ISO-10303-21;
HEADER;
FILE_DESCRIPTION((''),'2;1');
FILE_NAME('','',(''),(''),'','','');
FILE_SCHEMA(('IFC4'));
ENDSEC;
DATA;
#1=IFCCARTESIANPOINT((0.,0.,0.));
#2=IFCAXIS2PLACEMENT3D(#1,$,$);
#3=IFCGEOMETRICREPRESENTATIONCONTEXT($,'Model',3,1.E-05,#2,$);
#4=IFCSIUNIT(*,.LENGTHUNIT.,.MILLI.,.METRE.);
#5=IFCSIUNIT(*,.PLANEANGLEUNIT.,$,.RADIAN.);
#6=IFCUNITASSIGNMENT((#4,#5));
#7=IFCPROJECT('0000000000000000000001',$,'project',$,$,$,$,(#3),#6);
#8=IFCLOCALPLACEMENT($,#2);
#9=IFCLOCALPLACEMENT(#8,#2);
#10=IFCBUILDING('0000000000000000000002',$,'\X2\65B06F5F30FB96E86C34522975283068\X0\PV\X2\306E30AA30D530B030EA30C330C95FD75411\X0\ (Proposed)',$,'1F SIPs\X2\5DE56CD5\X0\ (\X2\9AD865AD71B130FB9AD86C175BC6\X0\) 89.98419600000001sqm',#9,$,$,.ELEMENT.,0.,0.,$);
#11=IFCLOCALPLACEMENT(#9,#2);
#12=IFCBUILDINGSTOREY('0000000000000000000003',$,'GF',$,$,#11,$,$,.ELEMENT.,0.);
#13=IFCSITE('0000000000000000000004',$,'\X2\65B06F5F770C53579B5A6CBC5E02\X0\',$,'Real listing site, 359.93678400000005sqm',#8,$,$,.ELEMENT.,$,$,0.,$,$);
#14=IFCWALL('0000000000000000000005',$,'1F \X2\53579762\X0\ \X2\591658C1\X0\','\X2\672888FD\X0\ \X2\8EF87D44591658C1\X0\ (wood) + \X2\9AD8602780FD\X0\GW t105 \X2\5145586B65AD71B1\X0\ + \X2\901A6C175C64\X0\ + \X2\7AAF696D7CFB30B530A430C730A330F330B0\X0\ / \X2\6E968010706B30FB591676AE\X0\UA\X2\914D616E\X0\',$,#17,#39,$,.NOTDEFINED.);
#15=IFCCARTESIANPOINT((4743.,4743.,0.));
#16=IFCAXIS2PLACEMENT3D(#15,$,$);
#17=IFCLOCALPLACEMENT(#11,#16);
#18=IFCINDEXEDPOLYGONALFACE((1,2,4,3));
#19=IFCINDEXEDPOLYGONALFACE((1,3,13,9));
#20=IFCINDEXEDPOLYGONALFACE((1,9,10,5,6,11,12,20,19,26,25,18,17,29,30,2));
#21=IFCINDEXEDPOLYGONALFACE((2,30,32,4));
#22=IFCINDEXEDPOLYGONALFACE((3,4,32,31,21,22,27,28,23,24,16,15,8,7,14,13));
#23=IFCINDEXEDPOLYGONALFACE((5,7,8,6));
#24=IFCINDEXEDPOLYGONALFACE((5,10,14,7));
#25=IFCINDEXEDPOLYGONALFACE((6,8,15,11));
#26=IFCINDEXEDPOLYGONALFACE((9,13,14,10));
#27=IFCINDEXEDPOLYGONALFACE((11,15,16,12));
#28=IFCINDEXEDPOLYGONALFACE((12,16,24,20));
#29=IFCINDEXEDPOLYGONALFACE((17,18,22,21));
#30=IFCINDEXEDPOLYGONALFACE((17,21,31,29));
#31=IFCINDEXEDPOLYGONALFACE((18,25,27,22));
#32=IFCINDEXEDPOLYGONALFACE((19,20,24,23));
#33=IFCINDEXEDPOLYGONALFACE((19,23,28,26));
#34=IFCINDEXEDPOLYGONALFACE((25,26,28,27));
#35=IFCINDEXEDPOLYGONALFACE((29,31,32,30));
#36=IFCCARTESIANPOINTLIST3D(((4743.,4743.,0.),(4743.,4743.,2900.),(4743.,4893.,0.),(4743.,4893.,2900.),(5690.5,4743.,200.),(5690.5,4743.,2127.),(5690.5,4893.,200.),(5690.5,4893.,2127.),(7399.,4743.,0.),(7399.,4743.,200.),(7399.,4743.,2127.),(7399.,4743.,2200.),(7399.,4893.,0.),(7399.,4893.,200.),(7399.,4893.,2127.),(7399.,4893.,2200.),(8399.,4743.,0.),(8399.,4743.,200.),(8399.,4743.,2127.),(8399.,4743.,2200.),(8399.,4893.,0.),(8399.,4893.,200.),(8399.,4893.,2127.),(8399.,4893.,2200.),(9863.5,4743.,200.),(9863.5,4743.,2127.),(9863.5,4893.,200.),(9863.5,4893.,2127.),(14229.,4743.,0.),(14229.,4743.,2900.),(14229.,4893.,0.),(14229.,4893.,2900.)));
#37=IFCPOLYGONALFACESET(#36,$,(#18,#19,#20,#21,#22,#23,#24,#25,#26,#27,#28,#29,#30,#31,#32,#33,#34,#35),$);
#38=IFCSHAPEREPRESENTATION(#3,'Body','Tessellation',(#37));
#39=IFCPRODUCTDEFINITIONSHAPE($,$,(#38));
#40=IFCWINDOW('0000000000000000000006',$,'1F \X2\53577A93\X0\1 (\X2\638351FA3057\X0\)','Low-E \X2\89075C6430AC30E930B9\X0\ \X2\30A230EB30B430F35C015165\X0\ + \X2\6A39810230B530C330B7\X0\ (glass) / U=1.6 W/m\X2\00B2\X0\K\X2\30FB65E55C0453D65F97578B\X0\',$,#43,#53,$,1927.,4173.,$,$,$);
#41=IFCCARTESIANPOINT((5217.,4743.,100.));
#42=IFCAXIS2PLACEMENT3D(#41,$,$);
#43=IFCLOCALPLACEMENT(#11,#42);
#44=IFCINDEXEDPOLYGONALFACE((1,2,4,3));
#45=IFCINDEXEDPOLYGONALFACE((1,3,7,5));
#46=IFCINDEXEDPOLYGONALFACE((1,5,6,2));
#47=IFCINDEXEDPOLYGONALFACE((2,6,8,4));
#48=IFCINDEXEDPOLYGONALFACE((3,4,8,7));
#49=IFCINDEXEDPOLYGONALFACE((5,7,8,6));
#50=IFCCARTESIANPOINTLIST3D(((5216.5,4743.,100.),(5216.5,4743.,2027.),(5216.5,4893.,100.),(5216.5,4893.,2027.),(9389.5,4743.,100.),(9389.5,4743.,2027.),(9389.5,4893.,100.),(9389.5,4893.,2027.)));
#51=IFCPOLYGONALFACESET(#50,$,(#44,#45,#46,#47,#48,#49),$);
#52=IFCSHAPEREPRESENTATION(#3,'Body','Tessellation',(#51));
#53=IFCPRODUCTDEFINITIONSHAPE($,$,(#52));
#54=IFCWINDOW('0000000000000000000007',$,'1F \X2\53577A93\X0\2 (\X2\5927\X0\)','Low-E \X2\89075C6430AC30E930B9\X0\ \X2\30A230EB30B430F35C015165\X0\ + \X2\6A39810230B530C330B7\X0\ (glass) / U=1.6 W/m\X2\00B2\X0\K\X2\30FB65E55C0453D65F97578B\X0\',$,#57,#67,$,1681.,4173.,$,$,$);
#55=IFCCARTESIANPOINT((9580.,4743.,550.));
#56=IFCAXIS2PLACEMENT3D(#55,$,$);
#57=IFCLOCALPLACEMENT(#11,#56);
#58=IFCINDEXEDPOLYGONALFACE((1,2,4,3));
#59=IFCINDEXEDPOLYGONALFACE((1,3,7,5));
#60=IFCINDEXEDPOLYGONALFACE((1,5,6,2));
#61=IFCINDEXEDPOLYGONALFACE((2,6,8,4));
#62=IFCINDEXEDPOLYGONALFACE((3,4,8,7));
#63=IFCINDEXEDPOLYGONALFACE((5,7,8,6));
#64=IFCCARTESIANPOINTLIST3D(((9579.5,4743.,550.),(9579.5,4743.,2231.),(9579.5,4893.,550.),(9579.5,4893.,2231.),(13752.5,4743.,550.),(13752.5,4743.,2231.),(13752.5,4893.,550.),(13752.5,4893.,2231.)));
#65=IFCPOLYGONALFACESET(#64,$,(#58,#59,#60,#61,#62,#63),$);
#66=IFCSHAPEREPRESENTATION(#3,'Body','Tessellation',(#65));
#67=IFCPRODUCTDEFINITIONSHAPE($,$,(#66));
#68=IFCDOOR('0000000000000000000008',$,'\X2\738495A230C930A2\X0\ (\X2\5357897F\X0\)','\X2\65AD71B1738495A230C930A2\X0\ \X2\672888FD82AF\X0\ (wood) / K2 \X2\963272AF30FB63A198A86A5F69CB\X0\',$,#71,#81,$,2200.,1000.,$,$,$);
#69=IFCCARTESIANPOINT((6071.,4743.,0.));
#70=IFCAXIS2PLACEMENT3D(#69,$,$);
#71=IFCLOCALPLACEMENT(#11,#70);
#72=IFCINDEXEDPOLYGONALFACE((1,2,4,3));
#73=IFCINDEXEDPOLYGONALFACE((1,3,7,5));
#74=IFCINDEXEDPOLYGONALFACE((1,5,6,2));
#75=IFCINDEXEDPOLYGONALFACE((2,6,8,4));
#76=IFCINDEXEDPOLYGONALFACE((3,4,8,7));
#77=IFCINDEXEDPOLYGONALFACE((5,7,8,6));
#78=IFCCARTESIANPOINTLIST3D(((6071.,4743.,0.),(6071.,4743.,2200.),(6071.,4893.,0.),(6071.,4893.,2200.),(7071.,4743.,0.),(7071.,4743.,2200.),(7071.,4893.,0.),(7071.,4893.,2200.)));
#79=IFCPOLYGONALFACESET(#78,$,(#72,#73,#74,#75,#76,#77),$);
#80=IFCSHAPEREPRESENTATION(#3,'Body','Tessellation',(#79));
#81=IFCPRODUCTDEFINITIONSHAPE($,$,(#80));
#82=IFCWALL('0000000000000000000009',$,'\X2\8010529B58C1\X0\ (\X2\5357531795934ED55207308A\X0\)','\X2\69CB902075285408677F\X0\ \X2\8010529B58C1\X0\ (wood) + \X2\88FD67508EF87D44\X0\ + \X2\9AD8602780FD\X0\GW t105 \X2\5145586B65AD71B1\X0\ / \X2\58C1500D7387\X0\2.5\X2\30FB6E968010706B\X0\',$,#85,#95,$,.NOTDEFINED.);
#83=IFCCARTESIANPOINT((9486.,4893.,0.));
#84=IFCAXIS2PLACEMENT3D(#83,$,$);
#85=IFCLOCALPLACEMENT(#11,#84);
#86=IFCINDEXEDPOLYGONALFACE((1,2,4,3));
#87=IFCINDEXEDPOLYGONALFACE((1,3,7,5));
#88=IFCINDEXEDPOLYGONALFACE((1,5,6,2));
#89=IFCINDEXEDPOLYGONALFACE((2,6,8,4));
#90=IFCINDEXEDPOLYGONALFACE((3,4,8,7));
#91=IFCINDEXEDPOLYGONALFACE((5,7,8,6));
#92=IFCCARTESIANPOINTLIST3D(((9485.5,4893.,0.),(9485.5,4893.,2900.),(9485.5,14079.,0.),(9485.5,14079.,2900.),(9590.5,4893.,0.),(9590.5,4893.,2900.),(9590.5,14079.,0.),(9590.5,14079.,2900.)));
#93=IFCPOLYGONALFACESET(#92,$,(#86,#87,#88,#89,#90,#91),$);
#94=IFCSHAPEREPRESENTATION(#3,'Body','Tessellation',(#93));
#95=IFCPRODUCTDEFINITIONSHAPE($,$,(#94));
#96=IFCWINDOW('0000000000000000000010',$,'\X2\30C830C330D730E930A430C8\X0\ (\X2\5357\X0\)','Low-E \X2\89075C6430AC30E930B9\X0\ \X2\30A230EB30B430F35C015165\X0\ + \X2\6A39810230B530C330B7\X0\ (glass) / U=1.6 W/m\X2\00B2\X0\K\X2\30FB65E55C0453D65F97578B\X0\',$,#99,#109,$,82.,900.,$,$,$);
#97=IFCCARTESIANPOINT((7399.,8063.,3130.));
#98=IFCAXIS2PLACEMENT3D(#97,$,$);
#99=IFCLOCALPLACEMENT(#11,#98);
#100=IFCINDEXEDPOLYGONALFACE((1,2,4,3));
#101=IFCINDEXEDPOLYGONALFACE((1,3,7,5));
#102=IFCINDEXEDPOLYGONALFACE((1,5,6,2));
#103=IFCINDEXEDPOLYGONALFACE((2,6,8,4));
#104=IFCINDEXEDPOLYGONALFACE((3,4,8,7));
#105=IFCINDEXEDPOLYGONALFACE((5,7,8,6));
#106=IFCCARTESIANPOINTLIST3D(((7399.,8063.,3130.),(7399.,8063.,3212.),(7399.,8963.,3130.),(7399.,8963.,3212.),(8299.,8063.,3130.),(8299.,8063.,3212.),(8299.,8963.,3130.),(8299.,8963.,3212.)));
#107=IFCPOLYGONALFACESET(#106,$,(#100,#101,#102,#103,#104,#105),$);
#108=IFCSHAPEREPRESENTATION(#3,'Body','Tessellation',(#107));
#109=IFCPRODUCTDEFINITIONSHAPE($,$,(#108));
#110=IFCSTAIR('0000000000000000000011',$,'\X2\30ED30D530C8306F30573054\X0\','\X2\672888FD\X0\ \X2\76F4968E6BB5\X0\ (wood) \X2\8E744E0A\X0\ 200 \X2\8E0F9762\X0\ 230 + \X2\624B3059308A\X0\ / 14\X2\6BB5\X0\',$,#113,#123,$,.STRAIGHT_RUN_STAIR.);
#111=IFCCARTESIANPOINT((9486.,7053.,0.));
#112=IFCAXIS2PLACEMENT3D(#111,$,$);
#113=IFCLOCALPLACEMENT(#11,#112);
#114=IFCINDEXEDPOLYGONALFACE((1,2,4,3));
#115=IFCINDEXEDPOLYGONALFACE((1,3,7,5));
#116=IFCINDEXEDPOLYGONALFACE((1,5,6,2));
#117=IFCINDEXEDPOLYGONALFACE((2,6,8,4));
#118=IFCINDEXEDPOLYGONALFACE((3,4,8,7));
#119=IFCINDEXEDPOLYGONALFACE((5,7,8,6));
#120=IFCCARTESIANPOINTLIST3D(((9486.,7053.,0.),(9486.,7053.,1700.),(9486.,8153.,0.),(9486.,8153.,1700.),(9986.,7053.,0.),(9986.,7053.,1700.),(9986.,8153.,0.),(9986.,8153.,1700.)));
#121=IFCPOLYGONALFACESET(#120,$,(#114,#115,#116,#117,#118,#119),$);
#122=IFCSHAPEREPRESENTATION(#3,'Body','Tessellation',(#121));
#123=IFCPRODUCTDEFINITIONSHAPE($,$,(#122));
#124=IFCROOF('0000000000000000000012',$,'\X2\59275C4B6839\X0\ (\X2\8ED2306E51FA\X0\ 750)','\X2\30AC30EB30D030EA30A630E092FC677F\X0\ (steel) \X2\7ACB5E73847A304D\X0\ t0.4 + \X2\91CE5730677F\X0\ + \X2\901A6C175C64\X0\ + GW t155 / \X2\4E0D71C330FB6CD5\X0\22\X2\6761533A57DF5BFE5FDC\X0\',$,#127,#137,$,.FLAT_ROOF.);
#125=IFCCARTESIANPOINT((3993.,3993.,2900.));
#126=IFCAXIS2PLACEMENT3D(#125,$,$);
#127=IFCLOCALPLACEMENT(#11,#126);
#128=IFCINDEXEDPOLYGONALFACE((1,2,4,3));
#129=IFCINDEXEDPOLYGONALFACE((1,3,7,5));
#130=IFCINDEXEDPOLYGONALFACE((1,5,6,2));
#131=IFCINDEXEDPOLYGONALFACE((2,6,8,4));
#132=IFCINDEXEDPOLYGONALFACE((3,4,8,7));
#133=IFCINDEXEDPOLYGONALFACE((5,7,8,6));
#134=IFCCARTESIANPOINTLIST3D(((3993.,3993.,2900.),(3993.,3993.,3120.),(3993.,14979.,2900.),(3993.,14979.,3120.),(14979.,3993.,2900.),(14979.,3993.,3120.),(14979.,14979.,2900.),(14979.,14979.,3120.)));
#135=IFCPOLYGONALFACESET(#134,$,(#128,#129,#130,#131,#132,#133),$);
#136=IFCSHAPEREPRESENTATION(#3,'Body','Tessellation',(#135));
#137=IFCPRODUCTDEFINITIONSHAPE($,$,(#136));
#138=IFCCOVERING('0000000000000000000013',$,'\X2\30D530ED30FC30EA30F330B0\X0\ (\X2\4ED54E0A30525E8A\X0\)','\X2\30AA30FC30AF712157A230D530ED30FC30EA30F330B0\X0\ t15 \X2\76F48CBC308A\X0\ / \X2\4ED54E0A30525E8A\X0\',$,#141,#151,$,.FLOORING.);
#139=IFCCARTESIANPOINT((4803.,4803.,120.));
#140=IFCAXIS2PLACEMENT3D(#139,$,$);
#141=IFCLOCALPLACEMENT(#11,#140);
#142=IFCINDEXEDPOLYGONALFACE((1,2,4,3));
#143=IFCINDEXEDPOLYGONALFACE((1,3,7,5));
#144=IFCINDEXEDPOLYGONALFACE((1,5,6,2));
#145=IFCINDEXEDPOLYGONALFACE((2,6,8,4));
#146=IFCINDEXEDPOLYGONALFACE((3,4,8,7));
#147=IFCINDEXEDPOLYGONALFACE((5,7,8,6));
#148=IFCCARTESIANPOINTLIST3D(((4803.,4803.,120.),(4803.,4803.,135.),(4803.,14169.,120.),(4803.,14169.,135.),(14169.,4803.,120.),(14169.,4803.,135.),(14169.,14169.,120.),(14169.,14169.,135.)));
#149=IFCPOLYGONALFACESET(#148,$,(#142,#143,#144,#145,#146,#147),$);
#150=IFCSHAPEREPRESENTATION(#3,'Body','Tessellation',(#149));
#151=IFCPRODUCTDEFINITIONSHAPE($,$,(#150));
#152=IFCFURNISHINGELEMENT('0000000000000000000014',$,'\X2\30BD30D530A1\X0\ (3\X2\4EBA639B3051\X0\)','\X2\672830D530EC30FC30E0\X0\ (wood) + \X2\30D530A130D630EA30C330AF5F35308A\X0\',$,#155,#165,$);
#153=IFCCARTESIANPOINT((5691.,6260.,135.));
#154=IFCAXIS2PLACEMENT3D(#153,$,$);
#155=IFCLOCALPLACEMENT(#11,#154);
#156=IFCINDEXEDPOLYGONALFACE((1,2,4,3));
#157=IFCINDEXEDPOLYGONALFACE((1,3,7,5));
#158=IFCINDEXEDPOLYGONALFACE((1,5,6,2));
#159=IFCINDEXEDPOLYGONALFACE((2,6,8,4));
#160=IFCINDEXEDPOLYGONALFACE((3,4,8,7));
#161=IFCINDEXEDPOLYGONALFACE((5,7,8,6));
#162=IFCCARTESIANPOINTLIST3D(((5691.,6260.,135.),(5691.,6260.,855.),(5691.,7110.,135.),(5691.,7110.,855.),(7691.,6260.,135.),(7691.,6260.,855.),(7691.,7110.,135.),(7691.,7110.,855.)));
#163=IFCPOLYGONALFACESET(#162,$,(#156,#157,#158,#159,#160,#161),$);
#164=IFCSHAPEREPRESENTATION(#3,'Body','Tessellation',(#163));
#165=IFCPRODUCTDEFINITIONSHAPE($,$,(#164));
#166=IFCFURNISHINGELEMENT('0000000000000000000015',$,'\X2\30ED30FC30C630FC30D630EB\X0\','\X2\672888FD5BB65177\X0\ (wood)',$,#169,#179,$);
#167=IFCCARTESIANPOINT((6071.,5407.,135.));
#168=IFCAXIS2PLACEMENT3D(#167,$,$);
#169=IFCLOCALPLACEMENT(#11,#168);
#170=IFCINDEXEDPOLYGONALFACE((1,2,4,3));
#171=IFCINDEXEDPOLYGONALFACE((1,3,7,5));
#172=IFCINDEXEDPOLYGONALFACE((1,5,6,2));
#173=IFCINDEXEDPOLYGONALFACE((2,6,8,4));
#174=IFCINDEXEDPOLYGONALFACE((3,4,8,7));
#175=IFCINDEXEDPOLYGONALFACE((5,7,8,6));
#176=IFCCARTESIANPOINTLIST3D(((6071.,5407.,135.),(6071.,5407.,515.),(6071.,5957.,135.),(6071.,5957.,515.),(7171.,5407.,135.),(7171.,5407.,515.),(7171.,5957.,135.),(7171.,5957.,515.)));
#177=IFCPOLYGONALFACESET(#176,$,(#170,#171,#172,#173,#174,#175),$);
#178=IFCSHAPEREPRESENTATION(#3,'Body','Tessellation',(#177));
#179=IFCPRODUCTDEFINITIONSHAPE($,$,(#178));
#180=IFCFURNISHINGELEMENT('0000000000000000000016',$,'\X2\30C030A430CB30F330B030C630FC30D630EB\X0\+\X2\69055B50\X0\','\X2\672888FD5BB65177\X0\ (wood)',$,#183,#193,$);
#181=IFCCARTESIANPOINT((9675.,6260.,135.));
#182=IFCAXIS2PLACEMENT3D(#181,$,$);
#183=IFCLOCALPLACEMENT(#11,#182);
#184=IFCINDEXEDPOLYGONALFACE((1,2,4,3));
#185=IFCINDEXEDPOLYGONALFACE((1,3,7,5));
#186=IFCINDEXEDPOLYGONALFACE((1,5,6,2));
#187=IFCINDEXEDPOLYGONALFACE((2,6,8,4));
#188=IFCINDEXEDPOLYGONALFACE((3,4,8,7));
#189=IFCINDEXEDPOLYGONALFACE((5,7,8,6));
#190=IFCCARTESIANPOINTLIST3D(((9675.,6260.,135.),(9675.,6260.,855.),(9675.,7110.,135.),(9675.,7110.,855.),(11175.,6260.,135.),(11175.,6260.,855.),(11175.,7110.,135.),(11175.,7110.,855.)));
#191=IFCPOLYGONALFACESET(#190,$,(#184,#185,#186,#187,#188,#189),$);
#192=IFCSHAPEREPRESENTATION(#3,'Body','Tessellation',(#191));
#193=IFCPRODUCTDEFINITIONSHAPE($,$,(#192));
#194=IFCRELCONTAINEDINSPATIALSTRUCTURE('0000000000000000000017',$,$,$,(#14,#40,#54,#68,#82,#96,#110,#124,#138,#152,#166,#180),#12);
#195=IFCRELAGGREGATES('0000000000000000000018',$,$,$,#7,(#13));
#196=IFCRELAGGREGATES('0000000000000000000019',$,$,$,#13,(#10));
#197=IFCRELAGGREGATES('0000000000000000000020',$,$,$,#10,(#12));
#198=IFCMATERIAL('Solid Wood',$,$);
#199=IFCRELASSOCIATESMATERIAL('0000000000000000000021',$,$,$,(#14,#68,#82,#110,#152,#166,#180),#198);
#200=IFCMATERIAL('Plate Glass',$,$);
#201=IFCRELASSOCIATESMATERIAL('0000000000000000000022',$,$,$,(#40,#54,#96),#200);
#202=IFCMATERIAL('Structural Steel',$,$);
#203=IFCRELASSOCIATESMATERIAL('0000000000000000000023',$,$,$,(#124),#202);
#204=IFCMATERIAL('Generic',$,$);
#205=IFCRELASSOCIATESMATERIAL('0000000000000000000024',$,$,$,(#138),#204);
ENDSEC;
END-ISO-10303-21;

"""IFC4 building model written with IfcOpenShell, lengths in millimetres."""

from ifc_helpers import new_model, si_unit, frame, frame_2d, origin, place, context, project, spatial, rectangle, extrude, material, element, fill, save


model = new_model("IFC4")

# Units and contexts
model_context = context("Model", 3, precision=1e-05, world=origin())
ifc_project = project(units=[si_unit("LENGTHUNIT", "METRE", prefix="MILLI"), si_unit("PLANEANGLEUNIT", "RADIAN")], contexts=[model_context])

# Site, building, storey
site_placement = place(None, origin())
site = spatial("IfcSite", under=ifc_project, at=site_placement, Name="新潟県南魚沼市", ObjectType="Real listing site, 359.93678400000005sqm", CompositionType="ELEMENT", RefElevation=0.0)
building_placement = place(site_placement, origin())
building = spatial("IfcBuilding", under=site, at=building_placement, Name="新潟・雨水利用とPVのオフグリッド志向 (Proposed)", ObjectType="1F SIPs工法 (高断熱・高気密) 89.98419600000001sqm", CompositionType="ELEMENT", ElevationOfRefHeight=0.0, ElevationOfTerrain=0.0)
storey_placement = place(building_placement, origin())
storey = spatial("IfcBuildingStorey", under=building, at=storey_placement, Name="GF", CompositionType="ELEMENT", Elevation=0.0)

# Shared definitions
ifc_material_1 = material(Name="Solid Wood")

# Wall, openings, windows, door
wall_1_placement = place(storey_placement, frame((4743.0, 4743.0, 0.0)))
wall_1 = element("IfcWall", 1, at=wall_1_placement, inside=storey, material=ifc_material_1, Name="1F 南面 外壁", Description="木製 軸組外壁 (wood) + 高性能GW t105 充填断熱 + 通気層 + 窯業系サイディング / 準耐火・外皮UA配慮", PredefinedType="NOTDEFINED", context=model_context, shape_type="SweptSolid", body=[
    extrude(rectangle(XDim=9486.0, YDim=150.0, at=frame_2d((4743.0, 75.0))), frame((4743.0, 4743.0, 0.0)), (0.0, 0.0, 1.0), 2900.0),
])
opening_1_placement = place(storey_placement, frame((5217.0, 4743.0, 100.0)))
opening_1 = element("IfcOpeningElement", 2, at=opening_1_placement, cuts=wall_1, PredefinedType="NOTDEFINED", context=model_context, shape_type="SweptSolid", body=[
    extrude(rectangle(XDim=4173.0, YDim=150.0, at=frame_2d((2086.0, 75.0))), frame((5217.0, 4743.0, 100.0)), (0.0, 0.0, 1.0), 1927.0),
])
opening_2_placement = place(storey_placement, frame((9580.0, 4743.0, 550.0)))
opening_2 = element("IfcOpeningElement", 3, at=opening_2_placement, cuts=wall_1, PredefinedType="NOTDEFINED", context=model_context, shape_type="SweptSolid", body=[
    extrude(rectangle(XDim=4173.0, YDim=150.0, at=frame_2d((2086.0, 75.0))), frame((9580.0, 4743.0, 550.0)), (0.0, 0.0, 1.0), 1681.0),
])
opening_3_placement = place(storey_placement, frame((6071.0, 4743.0, 0.0)))
opening_3 = element("IfcOpeningElement", 4, at=opening_3_placement, cuts=wall_1, PredefinedType="NOTDEFINED", context=model_context, shape_type="SweptSolid", body=[
    extrude(rectangle(XDim=1000.0, YDim=150.0, at=frame_2d((500.0, 75.0))), frame((6071.0, 4743.0, 0.0)), (0.0, 0.0, 1.0), 2200.0),
])
ifc_material_2 = material(Name="Plate Glass")
window_1_placement = place(storey_placement, frame((5217.0, 4743.0, 100.0)))
window_1 = element("IfcWindow", 5, at=window_1_placement, inside=storey, material=ifc_material_2, Name="1F 南窓1 (掃出し)", Description="Low-E 複層ガラス アルゴン封入 + 樹脂サッシ (glass) / U=1.6 W/m²K・日射取得型", OverallHeight=1927.0, OverallWidth=4173.0, context=model_context, shape_type="SweptSolid", body=[
    extrude(rectangle(XDim=4173.0, YDim=150.0, at=frame_2d((2086.0, 75.0))), frame((5217.0, 4743.0, 100.0)), (0.0, 0.0, 1.0), 1927.0),
])
fill(opening_1, window_1)
window_2_placement = place(storey_placement, frame((9580.0, 4743.0, 550.0)))
window_2 = element("IfcWindow", 6, at=window_2_placement, inside=storey, material=ifc_material_2, Name="1F 南窓2 (大)", Description="Low-E 複層ガラス アルゴン封入 + 樹脂サッシ (glass) / U=1.6 W/m²K・日射取得型", OverallHeight=1681.0, OverallWidth=4173.0, context=model_context, shape_type="SweptSolid", body=[
    extrude(rectangle(XDim=4173.0, YDim=150.0, at=frame_2d((2086.0, 75.0))), frame((9580.0, 4743.0, 550.0)), (0.0, 0.0, 1.0), 1681.0),
])
fill(opening_2, window_2)
door_placement = place(storey_placement, frame((6071.0, 4743.0, 0.0)))
door = element("IfcDoor", 7, at=door_placement, inside=storey, material=ifc_material_1, Name="玄関ドア (南西)", Description="断熱玄関ドア 木製芯 (wood) / K2 防犯・採風機構", OverallHeight=2200.0, OverallWidth=1000.0, context=model_context, shape_type="SweptSolid", body=[
    extrude(rectangle(XDim=1000.0, YDim=150.0, at=frame_2d((500.0, 75.0))), frame((6071.0, 4743.0, 0.0)), (0.0, 0.0, 1.0), 2200.0),
])
fill(opening_3, door)

# Wall
wall_2_placement = place(storey_placement, frame((9486.0, 4893.0, 0.0)))
element("IfcWall", 8, at=wall_2_placement, inside=storey, material=ifc_material_1, Name="耐力壁 (南北間仕切り)", Description="構造用合板 耐力壁 (wood) + 製材軸組 + 高性能GW t105 充填断熱 / 壁倍率2.5・準耐火", PredefinedType="NOTDEFINED", context=model_context, shape_type="SweptSolid", body=[
    extrude(rectangle(XDim=105.0, YDim=9186.0, at=frame_2d((52.0, 4593.0))), frame((9486.0, 4893.0, 0.0)), (0.0, 0.0, 1.0), 2900.0),
])

# Window
window_3_placement = place(storey_placement, frame((7399.0, 8063.0, 3130.0)))
element("IfcWindow", 9, at=window_3_placement, inside=storey, material=ifc_material_2, Name="トップライト (南)", Description="Low-E 複層ガラス アルゴン封入 + 樹脂サッシ (glass) / U=1.6 W/m²K・日射取得型", OverallHeight=82.0, OverallWidth=900.0, context=model_context, shape_type="SweptSolid", body=[
    extrude(rectangle(XDim=900.0, YDim=900.0, at=frame_2d((450.0, 450.0))), frame((7399.0, 8063.0, 3130.0)), (0.0, 0.0, 1.0), 82.0),
])

# Stair
stair_placement = place(storey_placement, frame((9486.0, 7053.0, 0.0)))
element("IfcStair", 10, at=stair_placement, inside=storey, material=ifc_material_1, Name="ロフトはしご", Description="木製 直階段 (wood) 蹴上 200 踏面 230 + 手すり / 14段", PredefinedType="STRAIGHT_RUN_STAIR", context=model_context, shape_type="SweptSolid", body=[
    extrude(rectangle(XDim=500.0, YDim=1100.0, at=frame_2d((250.0, 550.0))), frame((9486.0, 7053.0, 0.0)), (0.0, 0.0, 1.0), 1700.0),
])

# Roof
ifc_material_3 = material(Name="Structural Steel")
roof_placement = place(storey_placement, frame((3993.0, 3993.0, 2900.0)))
element("IfcRoof", 11, at=roof_placement, inside=storey, material=ifc_material_3, Name="大屋根 (軒の出 750)", Description="ガルバリウム鋼板 (steel) 立平葺き t0.4 + 野地板 + 通気層 + GW t155 / 不燃・法22条区域対応", PredefinedType="FLAT_ROOF", context=model_context, shape_type="SweptSolid", body=[
    extrude(rectangle(XDim=10986.0, YDim=10986.0, at=frame_2d((5493.0, 5493.0))), frame((3993.0, 3993.0, 2900.0)), (0.0, 0.0, 1.0), 220.0),
])

# Covering
ifc_material_4 = material(Name="Generic")
covering_placement = place(storey_placement, frame((4803.0, 4803.0, 120.0)))
element("IfcCovering", 12, at=covering_placement, inside=storey, material=ifc_material_4, Name="フローリング (仕上げ床)", Description="オーク無垢フローリング t15 直貼り / 仕上げ床", PredefinedType="FLOORING", context=model_context, shape_type="SweptSolid", body=[
    extrude(rectangle(XDim=9366.0, YDim=9366.0, at=frame_2d((4683.0, 4683.0))), frame((4803.0, 4803.0, 120.0)), (0.0, 0.0, 1.0), 15.0),
])

# Furnishing elements
furnishing_1_placement = place(storey_placement, frame((5691.0, 6260.0, 135.0)))
element("IfcFurnishingElement", 13, at=furnishing_1_placement, inside=storey, material=ifc_material_1, Name="ソファ (3人掛け)", Description="木フレーム (wood) + ファブリック張り", context=model_context, shape_type="SweptSolid", body=[
    extrude(rectangle(XDim=2000.0, YDim=850.0, at=frame_2d((1000.0, 425.0))), frame((5691.0, 6260.0, 135.0)), (0.0, 0.0, 1.0), 720.0),
])
furnishing_2_placement = place(storey_placement, frame((6071.0, 5407.0, 135.0)))
element("IfcFurnishingElement", 14, at=furnishing_2_placement, inside=storey, material=ifc_material_1, Name="ローテーブル", Description="木製家具 (wood)", context=model_context, shape_type="SweptSolid", body=[
    extrude(rectangle(XDim=1100.0, YDim=550.0, at=frame_2d((550.0, 275.0))), frame((6071.0, 5407.0, 135.0)), (0.0, 0.0, 1.0), 380.0),
])
furnishing_3_placement = place(storey_placement, frame((9675.0, 6260.0, 135.0)))
element("IfcFurnishingElement", 15, at=furnishing_3_placement, inside=storey, material=ifc_material_1, Name="ダイニングテーブル+椅子", Description="木製家具 (wood)", context=model_context, shape_type="SweptSolid", body=[
    extrude(rectangle(XDim=1500.0, YDim=850.0, at=frame_2d((750.0, 425.0))), frame((9675.0, 6260.0, 135.0)), (0.0, 0.0, 1.0), 720.0),
])

save(model, "model.ifc")
